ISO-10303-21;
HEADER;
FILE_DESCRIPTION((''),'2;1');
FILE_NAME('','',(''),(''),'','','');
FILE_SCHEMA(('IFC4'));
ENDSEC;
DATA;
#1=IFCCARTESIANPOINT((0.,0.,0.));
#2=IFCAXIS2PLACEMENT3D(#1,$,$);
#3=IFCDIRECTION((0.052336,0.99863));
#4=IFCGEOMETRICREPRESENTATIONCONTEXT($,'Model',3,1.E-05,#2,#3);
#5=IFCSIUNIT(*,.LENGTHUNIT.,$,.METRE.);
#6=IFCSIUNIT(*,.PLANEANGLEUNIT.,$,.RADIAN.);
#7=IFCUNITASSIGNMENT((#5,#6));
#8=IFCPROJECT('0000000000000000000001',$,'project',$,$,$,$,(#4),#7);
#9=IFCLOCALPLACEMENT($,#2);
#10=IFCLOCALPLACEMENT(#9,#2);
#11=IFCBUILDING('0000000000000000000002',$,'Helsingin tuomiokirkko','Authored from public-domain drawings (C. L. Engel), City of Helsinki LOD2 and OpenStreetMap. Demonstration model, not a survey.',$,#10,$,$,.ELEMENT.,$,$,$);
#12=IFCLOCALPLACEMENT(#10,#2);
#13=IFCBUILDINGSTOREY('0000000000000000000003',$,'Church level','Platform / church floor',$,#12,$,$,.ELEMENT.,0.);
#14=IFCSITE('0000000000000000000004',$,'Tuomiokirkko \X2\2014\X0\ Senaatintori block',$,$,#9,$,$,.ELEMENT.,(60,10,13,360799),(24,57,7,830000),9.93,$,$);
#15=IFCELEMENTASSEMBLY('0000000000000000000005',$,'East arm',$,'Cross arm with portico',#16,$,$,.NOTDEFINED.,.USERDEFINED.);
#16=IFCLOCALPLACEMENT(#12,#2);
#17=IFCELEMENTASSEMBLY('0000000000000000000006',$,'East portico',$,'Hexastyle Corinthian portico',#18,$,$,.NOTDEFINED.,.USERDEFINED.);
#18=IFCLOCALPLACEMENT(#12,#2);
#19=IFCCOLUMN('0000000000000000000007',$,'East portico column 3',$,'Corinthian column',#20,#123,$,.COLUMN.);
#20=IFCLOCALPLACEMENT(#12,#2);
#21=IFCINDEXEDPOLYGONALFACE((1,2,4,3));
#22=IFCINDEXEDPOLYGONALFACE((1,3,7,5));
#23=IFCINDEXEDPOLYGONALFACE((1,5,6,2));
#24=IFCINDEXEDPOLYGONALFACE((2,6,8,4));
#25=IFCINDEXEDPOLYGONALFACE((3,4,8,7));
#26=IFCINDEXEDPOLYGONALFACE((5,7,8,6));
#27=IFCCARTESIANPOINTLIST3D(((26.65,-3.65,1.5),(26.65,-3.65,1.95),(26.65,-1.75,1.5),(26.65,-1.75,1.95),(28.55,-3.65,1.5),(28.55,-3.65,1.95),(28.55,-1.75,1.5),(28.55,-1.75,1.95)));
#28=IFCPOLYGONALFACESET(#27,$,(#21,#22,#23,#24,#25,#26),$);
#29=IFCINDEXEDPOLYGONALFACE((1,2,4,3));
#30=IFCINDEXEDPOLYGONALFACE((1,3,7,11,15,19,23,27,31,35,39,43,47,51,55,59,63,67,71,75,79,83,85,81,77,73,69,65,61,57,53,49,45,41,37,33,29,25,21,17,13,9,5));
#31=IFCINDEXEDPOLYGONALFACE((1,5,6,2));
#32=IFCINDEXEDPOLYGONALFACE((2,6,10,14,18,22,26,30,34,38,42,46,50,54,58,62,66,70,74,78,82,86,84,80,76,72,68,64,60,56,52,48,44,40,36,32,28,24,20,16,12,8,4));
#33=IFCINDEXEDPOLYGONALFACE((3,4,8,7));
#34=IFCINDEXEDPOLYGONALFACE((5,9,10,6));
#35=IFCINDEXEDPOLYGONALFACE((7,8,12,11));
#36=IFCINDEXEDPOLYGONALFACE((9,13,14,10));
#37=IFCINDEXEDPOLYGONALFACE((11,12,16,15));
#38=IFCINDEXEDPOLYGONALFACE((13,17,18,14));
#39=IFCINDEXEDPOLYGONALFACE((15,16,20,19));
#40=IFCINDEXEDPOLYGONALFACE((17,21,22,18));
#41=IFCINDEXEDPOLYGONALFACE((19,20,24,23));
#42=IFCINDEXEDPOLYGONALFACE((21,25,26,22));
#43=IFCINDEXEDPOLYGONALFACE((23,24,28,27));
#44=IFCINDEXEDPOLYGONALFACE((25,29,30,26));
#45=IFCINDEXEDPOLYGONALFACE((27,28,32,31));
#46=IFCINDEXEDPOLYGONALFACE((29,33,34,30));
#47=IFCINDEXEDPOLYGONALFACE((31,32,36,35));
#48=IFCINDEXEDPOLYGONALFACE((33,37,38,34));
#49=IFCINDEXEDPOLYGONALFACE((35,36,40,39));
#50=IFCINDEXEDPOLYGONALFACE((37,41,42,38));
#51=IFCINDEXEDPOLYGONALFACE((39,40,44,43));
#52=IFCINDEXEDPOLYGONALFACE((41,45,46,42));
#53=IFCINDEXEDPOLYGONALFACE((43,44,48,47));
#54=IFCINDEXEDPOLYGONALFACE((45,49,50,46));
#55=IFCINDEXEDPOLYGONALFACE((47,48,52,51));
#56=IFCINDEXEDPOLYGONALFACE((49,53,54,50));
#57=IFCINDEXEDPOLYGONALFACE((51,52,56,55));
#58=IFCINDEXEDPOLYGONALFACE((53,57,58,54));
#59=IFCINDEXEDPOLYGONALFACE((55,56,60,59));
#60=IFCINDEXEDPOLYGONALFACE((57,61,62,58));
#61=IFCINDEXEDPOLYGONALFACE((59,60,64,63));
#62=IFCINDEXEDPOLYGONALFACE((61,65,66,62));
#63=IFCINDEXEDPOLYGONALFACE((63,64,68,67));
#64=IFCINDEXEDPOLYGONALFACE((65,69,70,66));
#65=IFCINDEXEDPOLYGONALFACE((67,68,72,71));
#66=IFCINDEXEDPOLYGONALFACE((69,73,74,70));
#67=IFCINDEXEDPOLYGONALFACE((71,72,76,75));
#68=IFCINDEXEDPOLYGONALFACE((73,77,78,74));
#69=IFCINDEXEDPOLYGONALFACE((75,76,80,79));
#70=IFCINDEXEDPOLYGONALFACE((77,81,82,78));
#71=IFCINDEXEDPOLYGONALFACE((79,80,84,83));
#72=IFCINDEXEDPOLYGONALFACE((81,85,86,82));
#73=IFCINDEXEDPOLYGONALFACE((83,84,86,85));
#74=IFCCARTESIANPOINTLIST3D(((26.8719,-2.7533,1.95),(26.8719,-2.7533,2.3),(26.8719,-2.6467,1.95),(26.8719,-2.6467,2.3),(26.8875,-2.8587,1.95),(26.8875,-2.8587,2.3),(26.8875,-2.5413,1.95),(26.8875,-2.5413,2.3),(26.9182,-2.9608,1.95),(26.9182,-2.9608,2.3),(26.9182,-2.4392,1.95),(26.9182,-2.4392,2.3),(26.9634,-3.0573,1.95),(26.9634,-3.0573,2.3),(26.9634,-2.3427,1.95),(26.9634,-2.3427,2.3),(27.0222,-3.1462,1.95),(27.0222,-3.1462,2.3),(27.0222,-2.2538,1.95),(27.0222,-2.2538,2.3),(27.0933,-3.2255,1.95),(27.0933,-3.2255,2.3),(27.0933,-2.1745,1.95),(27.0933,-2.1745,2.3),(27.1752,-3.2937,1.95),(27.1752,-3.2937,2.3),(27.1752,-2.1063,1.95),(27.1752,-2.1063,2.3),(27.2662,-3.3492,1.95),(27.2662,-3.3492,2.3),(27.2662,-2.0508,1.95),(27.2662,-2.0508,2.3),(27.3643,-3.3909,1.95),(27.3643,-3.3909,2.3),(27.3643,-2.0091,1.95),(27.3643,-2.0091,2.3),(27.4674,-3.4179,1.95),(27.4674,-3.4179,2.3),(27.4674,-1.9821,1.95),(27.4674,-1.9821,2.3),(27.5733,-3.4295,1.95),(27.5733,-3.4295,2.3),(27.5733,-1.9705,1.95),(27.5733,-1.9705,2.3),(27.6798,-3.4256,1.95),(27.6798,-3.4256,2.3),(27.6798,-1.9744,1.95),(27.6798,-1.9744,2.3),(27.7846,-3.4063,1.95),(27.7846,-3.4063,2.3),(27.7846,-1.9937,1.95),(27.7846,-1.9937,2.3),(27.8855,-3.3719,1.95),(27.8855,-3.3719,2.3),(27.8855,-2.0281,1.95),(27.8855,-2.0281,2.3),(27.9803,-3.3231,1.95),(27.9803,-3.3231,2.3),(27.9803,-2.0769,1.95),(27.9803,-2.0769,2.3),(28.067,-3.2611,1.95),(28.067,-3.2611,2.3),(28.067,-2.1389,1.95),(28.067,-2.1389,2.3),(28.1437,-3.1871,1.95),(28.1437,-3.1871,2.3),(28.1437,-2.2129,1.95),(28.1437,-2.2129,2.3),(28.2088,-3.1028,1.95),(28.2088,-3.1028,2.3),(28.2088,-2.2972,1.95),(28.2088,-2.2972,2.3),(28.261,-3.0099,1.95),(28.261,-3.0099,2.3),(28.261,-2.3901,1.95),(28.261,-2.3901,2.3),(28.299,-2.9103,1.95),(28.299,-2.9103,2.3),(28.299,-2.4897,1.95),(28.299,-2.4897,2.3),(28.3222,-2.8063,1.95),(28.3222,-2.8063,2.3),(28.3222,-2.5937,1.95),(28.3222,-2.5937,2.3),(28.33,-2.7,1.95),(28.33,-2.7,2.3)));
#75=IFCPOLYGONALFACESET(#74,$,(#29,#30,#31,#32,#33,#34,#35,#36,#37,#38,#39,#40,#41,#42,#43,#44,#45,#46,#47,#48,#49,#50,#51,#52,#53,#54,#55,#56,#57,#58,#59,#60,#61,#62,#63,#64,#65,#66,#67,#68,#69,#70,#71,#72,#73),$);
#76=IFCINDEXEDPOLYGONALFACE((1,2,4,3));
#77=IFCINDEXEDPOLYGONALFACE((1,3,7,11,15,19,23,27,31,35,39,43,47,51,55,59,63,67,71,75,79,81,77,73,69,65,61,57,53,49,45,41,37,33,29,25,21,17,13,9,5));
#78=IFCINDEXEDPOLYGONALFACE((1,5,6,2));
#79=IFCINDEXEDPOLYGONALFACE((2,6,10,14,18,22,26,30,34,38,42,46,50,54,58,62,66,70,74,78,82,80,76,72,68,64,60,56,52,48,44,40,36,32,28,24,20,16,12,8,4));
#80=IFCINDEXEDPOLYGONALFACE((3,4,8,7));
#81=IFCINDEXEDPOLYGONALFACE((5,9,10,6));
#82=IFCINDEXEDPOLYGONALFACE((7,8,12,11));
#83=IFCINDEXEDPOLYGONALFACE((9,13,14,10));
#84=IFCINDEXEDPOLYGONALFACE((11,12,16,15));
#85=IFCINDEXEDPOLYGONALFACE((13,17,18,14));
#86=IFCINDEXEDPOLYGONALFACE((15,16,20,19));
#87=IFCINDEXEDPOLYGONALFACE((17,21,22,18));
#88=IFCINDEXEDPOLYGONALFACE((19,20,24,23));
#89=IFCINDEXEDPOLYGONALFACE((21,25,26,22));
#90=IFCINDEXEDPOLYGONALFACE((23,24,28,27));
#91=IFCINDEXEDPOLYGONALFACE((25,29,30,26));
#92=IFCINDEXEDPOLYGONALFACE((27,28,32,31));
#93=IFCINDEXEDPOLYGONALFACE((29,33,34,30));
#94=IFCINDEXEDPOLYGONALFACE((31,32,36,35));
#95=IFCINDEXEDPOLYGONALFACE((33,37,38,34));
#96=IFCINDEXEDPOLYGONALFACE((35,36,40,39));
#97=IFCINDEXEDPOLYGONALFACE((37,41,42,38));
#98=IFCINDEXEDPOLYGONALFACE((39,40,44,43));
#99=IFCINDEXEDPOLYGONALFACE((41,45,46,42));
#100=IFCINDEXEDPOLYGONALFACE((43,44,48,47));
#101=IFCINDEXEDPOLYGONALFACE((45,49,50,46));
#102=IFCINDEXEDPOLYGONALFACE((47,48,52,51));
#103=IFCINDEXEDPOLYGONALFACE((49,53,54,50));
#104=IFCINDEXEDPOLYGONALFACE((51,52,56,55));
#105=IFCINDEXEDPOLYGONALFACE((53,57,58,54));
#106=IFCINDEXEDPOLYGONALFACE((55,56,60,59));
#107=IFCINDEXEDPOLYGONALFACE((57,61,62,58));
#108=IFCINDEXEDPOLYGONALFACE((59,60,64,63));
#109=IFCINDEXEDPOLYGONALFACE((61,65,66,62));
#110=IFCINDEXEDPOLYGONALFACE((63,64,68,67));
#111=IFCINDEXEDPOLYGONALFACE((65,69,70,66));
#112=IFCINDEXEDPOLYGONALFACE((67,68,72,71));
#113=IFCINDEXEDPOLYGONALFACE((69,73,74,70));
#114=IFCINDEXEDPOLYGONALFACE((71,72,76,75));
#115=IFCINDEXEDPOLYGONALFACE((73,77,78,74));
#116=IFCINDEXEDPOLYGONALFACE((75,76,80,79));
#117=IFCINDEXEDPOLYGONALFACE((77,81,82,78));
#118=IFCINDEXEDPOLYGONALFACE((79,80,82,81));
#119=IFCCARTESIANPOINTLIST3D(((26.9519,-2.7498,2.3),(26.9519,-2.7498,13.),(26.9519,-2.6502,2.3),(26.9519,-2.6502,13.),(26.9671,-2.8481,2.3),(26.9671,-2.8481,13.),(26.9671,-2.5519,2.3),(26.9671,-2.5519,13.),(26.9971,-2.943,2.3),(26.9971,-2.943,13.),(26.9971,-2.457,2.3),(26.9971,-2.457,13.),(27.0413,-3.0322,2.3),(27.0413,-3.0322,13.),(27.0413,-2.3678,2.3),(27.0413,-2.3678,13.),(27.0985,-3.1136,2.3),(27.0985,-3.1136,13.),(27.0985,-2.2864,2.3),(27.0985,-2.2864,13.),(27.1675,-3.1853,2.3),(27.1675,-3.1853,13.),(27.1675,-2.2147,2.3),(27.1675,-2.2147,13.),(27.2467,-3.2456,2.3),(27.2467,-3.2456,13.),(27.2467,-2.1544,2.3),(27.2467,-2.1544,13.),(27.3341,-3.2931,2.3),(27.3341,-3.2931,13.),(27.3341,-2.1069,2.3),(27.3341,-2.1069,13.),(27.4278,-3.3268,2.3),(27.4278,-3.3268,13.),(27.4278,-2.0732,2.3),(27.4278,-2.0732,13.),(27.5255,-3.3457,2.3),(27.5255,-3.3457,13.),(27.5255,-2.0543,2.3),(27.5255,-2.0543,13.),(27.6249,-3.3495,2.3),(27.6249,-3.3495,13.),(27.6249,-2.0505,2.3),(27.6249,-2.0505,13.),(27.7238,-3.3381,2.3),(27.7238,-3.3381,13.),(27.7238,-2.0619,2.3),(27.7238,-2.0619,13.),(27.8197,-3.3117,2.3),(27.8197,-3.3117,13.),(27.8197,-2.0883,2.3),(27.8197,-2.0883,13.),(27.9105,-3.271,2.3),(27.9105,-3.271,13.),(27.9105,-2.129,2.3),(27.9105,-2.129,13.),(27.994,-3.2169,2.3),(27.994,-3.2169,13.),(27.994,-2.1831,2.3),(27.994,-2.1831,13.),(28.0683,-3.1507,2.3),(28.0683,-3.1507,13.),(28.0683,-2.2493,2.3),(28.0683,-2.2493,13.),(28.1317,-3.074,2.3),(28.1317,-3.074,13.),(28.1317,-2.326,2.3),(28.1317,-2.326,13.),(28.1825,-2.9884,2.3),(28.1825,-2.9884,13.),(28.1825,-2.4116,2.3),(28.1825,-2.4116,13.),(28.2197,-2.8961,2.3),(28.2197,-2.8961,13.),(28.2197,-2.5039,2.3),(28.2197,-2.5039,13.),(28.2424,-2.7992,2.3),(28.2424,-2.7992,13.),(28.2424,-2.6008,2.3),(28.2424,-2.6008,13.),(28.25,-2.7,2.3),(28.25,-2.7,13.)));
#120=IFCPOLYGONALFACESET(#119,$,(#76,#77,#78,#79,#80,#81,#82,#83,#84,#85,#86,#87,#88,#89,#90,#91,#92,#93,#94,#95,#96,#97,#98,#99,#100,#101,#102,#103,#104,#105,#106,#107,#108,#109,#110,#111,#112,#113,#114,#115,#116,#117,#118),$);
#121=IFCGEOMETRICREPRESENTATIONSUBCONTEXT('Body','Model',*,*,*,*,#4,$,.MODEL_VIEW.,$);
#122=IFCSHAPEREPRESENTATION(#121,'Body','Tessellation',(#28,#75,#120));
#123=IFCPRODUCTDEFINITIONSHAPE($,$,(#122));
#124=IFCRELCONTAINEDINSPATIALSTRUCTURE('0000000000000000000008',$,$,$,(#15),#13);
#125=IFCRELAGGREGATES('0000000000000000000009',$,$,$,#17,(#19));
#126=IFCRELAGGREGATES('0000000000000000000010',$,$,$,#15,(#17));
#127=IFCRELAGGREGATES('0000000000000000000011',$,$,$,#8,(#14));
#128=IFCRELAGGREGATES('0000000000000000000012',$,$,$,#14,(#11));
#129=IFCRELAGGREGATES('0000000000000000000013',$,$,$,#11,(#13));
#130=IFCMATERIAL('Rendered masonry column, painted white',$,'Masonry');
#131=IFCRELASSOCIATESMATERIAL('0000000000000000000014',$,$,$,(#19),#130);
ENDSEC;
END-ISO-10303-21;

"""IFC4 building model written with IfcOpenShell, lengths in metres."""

from ifc_helpers import new_model, si_unit, direction, frame, origin, origin_2d_with_axis, place, context, subcontext, project, spatial, rectangle, circle, extrude, material, element, aggregate, save


model = new_model("IFC4")

# Units and contexts
model_context = context("Model", 3, precision=1e-05, world=origin(), true_north=direction((0.052336, 0.99863)))
body_context = subcontext(model_context, "Body", "Model", "MODEL_VIEW")
ifc_project = project(units=[si_unit("LENGTHUNIT", "METRE"), si_unit("PLANEANGLEUNIT", "RADIAN")], contexts=[model_context])

# Site, building, storey
site_placement = place(None, origin())
site = spatial("IfcSite", under=ifc_project, at=site_placement, Name="Tuomiokirkko — Senaatintori block", CompositionType="ELEMENT", RefLatitude=(60, 10, 13, 360799), RefLongitude=(24, 57, 7, 830000), RefElevation=9.93)
building_placement = place(site_placement, origin())
building = spatial("IfcBuilding", under=site, at=building_placement, Name="Helsingin tuomiokirkko", Description="Authored from public-domain drawings (C. L. Engel), City of Helsinki LOD2 and OpenStreetMap. Demonstration model, not a survey.", CompositionType="ELEMENT")
storey_placement = place(building_placement, origin())
storey = spatial("IfcBuildingStorey", under=building, at=storey_placement, Name="Church level", Description="Platform / church floor", CompositionType="ELEMENT", Elevation=0.0)

# Shared definitions
ifc_material_1 = material(Name="Rendered masonry column, painted white", Category="Masonry")

# Element assemblies, column
assembly_1_placement = place(building_placement, origin())
assembly_1 = element("IfcElementAssembly", 1, at=assembly_1_placement, inside=storey, Name="East arm", ObjectType="Cross arm with portico", AssemblyPlace="NOTDEFINED", PredefinedType="USERDEFINED")
assembly_2_placement = place(building_placement, origin())
assembly_2 = element("IfcElementAssembly", 2, at=assembly_2_placement, Name="East portico", ObjectType="Hexastyle Corinthian portico", AssemblyPlace="NOTDEFINED", PredefinedType="USERDEFINED")
column_1_placement = place(building_placement, origin())
column_1 = element("IfcColumn", 3, at=column_1_placement, material=ifc_material_1, Name="East portico column 3", ObjectType="Corinthian column", PredefinedType="COLUMN", context=body_context, shape_type="SweptSolid", body=[
    extrude(rectangle(XDim=1.9, YDim=1.9, at=origin_2d_with_axis()), frame((27.6, -2.7, 1.5)), (0.0, 0.0, 1.0), 0.45),
    extrude(circle(Radius=0.73, at=origin_2d_with_axis()), frame((27.6, -2.7, 1.95)), (0.0, 0.0, 1.0), 0.35),
    extrude(circle(Radius=0.65, at=origin_2d_with_axis()), frame((27.6, -2.7, 2.3)), (0.0, 0.0, 1.0), 10.7),
])

aggregate(assembly_2, [column_1])

aggregate(assembly_1, [assembly_2])

save(model, "model.ifc")
